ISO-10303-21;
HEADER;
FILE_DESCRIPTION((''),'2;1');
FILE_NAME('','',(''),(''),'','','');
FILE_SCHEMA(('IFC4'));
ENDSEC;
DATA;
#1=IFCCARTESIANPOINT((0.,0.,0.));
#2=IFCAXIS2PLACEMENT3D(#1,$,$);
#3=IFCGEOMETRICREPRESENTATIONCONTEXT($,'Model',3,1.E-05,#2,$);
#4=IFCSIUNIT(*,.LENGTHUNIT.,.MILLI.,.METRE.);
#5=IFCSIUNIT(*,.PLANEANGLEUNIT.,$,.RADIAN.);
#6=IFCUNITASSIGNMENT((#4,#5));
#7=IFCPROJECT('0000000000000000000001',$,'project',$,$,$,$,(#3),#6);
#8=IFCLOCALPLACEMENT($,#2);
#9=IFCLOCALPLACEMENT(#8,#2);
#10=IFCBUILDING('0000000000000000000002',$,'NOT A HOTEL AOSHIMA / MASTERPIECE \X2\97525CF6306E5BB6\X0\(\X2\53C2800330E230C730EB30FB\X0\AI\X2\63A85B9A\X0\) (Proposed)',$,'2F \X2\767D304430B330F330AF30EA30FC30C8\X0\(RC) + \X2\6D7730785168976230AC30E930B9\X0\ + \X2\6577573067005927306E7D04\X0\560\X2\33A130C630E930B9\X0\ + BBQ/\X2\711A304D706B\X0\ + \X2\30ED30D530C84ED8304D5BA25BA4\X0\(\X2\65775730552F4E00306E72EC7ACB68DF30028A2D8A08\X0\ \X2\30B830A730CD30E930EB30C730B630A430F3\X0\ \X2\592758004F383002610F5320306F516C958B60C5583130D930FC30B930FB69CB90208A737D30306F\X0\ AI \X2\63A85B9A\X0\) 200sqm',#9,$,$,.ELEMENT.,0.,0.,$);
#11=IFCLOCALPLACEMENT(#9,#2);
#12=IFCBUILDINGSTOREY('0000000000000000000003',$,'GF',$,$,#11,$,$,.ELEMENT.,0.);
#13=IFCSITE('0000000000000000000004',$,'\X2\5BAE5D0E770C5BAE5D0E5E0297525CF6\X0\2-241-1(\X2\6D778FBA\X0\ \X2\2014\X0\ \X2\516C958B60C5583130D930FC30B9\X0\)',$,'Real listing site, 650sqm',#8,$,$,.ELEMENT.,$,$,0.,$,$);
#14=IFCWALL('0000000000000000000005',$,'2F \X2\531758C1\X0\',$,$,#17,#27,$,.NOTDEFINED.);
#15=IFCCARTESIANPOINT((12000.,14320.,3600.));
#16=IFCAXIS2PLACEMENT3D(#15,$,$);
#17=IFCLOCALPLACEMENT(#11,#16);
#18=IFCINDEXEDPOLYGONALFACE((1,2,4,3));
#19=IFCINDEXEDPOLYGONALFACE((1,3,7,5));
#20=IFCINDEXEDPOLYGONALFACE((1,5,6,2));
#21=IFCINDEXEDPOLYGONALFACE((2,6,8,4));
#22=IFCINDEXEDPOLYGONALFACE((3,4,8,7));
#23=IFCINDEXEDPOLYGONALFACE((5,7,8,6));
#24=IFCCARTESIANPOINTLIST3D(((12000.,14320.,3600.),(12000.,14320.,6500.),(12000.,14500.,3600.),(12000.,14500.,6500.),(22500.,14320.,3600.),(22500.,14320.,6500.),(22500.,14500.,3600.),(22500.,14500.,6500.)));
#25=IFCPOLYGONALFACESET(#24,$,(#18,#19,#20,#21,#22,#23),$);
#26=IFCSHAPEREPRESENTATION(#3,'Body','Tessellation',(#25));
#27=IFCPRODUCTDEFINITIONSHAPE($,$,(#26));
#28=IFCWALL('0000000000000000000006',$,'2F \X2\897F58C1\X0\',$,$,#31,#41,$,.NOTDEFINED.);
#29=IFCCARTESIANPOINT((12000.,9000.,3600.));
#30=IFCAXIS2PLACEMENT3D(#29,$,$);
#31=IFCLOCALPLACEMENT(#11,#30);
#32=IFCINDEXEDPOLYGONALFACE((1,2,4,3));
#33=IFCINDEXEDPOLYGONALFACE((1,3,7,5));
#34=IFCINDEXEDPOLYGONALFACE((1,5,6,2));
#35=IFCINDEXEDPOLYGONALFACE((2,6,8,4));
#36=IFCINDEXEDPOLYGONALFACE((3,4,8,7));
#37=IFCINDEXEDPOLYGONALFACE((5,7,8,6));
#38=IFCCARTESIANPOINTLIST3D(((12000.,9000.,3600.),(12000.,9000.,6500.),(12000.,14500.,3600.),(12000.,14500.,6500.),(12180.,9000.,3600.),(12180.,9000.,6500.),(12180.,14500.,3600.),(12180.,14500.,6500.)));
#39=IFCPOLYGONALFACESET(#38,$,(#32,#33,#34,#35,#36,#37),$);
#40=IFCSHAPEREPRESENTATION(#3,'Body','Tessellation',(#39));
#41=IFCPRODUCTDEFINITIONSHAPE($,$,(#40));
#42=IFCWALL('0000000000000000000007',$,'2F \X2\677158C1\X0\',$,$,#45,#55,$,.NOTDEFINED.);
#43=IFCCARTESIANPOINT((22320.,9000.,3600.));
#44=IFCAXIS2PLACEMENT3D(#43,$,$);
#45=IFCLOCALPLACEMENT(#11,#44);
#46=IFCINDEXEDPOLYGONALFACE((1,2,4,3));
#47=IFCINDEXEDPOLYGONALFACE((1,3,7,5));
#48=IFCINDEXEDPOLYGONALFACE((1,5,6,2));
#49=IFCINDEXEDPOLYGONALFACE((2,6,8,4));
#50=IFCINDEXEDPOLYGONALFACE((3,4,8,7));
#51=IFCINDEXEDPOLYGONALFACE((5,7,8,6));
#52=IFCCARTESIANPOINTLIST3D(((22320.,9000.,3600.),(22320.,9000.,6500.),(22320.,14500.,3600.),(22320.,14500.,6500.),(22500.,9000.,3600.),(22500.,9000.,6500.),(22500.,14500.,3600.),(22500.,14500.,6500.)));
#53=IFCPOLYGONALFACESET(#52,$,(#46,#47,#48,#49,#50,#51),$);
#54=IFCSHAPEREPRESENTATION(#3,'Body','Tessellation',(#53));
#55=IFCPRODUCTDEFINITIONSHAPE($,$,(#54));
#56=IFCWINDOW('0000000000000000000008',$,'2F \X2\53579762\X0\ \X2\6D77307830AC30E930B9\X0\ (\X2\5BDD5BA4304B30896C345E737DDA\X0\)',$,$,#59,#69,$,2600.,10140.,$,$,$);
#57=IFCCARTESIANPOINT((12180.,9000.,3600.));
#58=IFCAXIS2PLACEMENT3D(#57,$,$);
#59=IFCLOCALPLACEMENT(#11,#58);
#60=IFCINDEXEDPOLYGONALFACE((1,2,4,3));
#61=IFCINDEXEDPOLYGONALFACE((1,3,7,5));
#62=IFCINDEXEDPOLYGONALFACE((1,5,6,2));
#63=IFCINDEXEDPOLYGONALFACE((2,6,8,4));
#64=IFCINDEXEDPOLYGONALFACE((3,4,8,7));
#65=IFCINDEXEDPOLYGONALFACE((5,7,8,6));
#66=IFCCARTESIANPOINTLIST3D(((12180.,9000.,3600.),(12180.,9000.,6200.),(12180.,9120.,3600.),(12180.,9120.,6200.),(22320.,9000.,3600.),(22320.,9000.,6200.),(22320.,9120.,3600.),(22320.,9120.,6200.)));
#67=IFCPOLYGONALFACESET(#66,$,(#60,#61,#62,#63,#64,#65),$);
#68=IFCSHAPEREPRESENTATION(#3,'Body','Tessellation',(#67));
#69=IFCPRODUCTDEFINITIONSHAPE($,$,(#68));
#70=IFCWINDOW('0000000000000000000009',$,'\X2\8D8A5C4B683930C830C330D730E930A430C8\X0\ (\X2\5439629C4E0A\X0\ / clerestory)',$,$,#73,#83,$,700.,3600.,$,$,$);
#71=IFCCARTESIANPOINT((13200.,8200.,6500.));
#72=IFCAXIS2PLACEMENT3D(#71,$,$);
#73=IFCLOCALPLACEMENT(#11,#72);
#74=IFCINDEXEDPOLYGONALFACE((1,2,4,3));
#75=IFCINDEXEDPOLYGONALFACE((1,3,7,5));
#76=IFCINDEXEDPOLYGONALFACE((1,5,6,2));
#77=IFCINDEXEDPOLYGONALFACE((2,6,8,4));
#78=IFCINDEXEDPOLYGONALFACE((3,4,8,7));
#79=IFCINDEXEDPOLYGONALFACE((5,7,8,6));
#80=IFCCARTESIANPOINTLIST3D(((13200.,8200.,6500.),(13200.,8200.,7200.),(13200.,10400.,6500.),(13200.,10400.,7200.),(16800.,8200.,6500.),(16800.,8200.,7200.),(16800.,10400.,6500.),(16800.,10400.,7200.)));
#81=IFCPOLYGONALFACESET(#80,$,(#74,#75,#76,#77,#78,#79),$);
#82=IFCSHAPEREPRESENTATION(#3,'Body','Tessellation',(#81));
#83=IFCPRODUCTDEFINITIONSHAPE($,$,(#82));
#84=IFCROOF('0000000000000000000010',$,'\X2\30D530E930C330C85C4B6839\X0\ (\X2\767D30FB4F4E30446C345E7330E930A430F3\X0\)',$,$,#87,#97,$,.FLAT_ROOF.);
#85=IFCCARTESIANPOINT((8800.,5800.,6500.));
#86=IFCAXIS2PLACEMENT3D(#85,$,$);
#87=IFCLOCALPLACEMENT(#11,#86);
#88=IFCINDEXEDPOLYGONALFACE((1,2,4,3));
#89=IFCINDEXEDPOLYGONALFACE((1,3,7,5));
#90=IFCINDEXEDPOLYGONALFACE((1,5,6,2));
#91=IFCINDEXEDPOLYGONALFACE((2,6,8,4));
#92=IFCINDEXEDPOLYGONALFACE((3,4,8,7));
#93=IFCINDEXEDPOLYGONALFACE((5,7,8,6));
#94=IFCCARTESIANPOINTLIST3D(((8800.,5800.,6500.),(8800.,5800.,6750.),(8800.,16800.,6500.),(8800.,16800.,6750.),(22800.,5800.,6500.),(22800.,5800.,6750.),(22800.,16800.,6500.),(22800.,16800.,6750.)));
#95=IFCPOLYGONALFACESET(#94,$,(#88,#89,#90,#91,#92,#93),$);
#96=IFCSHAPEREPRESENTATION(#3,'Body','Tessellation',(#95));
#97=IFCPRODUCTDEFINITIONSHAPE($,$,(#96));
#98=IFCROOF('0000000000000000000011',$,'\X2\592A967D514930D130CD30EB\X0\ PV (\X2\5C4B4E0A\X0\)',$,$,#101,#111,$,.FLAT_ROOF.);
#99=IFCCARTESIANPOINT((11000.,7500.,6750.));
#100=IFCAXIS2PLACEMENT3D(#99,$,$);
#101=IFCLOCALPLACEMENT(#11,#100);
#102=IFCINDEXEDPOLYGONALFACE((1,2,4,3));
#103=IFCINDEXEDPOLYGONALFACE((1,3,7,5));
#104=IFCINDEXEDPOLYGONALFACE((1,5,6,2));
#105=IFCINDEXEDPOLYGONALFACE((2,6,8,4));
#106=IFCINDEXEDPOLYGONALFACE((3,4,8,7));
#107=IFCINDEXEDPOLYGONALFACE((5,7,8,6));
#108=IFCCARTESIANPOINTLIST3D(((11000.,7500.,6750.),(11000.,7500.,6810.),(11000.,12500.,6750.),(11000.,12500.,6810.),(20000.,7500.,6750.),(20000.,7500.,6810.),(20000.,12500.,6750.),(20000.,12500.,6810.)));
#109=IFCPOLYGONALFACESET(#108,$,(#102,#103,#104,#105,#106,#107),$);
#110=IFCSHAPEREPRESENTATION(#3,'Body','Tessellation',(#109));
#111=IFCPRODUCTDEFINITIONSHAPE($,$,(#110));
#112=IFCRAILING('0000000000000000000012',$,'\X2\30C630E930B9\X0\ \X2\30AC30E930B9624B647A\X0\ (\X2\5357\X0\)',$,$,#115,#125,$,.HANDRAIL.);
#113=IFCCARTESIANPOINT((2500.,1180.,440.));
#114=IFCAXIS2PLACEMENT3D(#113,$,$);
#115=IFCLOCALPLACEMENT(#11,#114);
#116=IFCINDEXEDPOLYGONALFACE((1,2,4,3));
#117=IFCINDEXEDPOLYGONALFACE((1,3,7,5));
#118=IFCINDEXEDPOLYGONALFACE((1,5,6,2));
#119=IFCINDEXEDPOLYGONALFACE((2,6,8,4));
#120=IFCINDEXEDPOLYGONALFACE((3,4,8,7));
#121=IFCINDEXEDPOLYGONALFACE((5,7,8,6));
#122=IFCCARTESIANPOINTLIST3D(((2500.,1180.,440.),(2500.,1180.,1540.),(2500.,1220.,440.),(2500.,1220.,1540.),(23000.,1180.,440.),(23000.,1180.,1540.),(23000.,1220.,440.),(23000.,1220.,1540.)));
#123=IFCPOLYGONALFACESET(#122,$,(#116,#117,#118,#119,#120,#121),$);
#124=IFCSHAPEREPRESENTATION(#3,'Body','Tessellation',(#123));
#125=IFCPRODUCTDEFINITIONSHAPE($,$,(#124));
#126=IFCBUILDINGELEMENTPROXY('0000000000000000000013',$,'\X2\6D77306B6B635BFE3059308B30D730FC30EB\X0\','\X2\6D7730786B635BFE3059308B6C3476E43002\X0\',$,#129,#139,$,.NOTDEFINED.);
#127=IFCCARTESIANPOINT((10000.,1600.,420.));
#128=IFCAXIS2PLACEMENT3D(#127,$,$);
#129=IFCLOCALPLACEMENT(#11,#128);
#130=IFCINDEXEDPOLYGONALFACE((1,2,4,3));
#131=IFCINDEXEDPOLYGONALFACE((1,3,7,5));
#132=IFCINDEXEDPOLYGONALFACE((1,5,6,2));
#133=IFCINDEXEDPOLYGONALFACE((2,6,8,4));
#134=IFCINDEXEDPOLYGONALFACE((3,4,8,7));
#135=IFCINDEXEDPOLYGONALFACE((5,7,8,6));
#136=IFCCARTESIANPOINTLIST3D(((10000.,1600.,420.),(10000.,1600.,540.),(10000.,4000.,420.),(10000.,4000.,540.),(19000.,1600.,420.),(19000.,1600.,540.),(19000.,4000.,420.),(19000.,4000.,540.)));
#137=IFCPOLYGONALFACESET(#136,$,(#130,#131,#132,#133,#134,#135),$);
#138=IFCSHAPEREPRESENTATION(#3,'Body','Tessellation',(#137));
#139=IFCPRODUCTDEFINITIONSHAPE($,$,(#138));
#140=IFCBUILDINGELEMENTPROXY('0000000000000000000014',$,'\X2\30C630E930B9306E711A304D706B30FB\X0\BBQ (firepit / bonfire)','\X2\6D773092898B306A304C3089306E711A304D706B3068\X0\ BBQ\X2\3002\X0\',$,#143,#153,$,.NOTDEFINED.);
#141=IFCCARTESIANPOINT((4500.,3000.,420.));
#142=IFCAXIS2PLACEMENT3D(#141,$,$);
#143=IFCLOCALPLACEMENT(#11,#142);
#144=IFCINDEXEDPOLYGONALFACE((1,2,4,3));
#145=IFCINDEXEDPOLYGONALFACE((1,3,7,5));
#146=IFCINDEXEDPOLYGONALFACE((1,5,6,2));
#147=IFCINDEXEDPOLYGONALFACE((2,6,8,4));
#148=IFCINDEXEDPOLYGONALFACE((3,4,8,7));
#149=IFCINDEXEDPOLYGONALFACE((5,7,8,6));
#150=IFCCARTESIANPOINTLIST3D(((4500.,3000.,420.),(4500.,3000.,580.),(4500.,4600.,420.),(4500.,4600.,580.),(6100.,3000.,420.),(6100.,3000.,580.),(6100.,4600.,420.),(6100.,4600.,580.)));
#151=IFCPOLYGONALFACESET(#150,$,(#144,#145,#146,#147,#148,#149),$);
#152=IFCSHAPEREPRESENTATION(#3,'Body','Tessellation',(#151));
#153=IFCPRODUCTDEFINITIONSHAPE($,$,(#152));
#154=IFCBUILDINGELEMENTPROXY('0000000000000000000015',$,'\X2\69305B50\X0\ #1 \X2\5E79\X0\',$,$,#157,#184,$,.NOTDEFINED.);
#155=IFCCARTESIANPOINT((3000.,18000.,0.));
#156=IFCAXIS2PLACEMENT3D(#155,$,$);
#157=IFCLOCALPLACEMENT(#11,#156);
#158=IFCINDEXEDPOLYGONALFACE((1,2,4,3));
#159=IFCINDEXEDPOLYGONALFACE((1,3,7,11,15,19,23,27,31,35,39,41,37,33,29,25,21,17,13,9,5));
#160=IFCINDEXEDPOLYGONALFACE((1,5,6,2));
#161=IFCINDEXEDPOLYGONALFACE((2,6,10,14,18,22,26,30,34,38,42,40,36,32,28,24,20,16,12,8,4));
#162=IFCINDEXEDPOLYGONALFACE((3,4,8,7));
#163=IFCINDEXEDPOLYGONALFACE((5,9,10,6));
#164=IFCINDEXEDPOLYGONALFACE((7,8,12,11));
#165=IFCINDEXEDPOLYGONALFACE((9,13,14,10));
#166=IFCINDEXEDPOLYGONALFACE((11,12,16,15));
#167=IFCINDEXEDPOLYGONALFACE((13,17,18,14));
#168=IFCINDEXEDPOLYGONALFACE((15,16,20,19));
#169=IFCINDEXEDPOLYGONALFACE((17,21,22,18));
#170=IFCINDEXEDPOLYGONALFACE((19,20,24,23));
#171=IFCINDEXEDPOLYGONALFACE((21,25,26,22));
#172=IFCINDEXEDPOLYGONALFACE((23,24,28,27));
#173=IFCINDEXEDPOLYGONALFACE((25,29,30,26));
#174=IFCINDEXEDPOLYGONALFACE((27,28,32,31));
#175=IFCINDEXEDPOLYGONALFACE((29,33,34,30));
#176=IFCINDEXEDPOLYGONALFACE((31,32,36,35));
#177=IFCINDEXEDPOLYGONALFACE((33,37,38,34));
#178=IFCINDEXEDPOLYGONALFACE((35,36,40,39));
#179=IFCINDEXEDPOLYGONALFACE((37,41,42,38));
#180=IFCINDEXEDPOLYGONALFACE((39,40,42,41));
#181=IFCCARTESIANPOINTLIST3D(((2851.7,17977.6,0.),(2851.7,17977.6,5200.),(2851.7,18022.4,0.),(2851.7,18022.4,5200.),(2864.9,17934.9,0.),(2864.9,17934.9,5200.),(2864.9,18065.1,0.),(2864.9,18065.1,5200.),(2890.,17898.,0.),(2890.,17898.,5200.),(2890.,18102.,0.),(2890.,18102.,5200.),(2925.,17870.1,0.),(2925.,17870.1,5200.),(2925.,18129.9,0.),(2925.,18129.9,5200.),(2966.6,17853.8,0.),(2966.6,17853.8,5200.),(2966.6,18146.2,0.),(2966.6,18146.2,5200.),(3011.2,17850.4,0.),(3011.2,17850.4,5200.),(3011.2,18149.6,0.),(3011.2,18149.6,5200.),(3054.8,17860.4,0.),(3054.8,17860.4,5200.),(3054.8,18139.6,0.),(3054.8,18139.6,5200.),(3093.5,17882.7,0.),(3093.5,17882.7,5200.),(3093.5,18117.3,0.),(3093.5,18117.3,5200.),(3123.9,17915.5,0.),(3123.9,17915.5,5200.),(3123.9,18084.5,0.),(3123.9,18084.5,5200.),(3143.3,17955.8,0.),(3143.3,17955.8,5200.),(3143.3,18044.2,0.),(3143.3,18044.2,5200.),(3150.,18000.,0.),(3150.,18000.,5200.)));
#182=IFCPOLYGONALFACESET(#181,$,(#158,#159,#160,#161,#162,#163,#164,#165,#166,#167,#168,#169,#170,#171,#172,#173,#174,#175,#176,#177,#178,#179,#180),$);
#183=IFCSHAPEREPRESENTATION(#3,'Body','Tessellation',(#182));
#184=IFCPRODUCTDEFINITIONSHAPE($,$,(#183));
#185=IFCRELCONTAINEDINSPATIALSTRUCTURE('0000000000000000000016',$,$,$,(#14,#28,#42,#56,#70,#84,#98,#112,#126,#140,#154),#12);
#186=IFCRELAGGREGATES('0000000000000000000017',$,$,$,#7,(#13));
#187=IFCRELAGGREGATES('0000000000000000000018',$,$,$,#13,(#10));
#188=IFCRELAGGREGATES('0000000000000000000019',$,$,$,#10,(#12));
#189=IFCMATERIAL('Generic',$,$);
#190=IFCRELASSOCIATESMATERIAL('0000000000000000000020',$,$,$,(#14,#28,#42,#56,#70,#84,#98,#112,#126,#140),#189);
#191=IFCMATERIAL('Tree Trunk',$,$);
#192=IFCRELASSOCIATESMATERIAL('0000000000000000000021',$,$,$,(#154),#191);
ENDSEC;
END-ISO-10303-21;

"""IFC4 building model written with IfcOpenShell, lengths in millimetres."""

from ifc_helpers import new_model, si_unit, frame, frame_2d, origin, origin_2d, place, context, project, spatial, rectangle, circle, extrude, material, element, save


model = new_model("IFC4")

# Units and contexts
model_context = context("Model", 3, precision=1e-05, world=origin())
ifc_project = project(units=[si_unit("LENGTHUNIT", "METRE", prefix="MILLI"), si_unit("PLANEANGLEUNIT", "RADIAN")], contexts=[model_context])

# Site, building, storey
site_placement = place(None, origin())
site = spatial("IfcSite", under=ifc_project, at=site_placement, Name="宮崎県宮崎市青島2-241-1(海辺 — 公開情報ベース)", ObjectType="Real listing site, 650sqm", CompositionType="ELEMENT", RefElevation=0.0)
building_placement = place(site_placement, origin())
building = spatial("IfcBuilding", under=site, at=building_placement, Name="NOT A HOTEL AOSHIMA / MASTERPIECE 青島の家(参考モデル・AI推定) (Proposed)", ObjectType="2F 白いコンクリート(RC) + 海へ全面ガラス + 敷地最大の約560㎡テラス + BBQ/焚き火 + ロフト付き客室(敷地唯一の独立棟。設計 ジェネラルデザイン 大堀伸。意匠は公開情報ベース・構造詳細は AI 推定) 200sqm", CompositionType="ELEMENT", ElevationOfRefHeight=0.0, ElevationOfTerrain=0.0)
storey_placement = place(building_placement, origin())
storey = spatial("IfcBuildingStorey", under=building, at=storey_placement, Name="GF", CompositionType="ELEMENT", Elevation=0.0)

# Shared definitions
ifc_material_1 = material(Name="Generic")

# Walls
wall_1_placement = place(storey_placement, frame((12000.0, 14320.0, 3600.0)))
element("IfcWall", 1, at=wall_1_placement, inside=storey, material=ifc_material_1, Name="2F 北壁", PredefinedType="NOTDEFINED", context=model_context, shape_type="SweptSolid", body=[
    extrude(rectangle(XDim=10500.0, YDim=180.0, at=frame_2d((5250.0, 90.0))), frame((12000.0, 14320.0, 3600.0)), (0.0, 0.0, 1.0), 2900.0),
])
wall_2_placement = place(storey_placement, frame((12000.0, 9000.0, 3600.0)))
element("IfcWall", 2, at=wall_2_placement, inside=storey, material=ifc_material_1, Name="2F 西壁", PredefinedType="NOTDEFINED", context=model_context, shape_type="SweptSolid", body=[
    extrude(rectangle(XDim=180.0, YDim=5500.0, at=frame_2d((90.0, 2750.0))), frame((12000.0, 9000.0, 3600.0)), (0.0, 0.0, 1.0), 2900.0),
])
wall_3_placement = place(storey_placement, frame((22320.0, 9000.0, 3600.0)))
element("IfcWall", 3, at=wall_3_placement, inside=storey, material=ifc_material_1, Name="2F 東壁", PredefinedType="NOTDEFINED", context=model_context, shape_type="SweptSolid", body=[
    extrude(rectangle(XDim=180.0, YDim=5500.0, at=frame_2d((90.0, 2750.0))), frame((22320.0, 9000.0, 3600.0)), (0.0, 0.0, 1.0), 2900.0),
])

# Windows
window_1_placement = place(storey_placement, frame((12180.0, 9000.0, 3600.0)))
element("IfcWindow", 4, at=window_1_placement, inside=storey, material=ifc_material_1, Name="2F 南面 海へガラス (寝室から水平線)", OverallHeight=2600.0, OverallWidth=10140.0, context=model_context, shape_type="SweptSolid", body=[
    extrude(rectangle(XDim=10140.0, YDim=120.0, at=frame_2d((5070.0, 60.0))), frame((12180.0, 9000.0, 3600.0)), (0.0, 0.0, 1.0), 2600.0),
])
window_2_placement = place(storey_placement, frame((13200.0, 8200.0, 6500.0)))
element("IfcWindow", 5, at=window_2_placement, inside=storey, material=ifc_material_1, Name="越屋根トップライト (吹抜上 / clerestory)", OverallHeight=700.0, OverallWidth=3600.0, context=model_context, shape_type="SweptSolid", body=[
    extrude(rectangle(XDim=3600.0, YDim=2200.0, at=frame_2d((1800.0, 1100.0))), frame((13200.0, 8200.0, 6500.0)), (0.0, 0.0, 1.0), 700.0),
])

# Roofs
roof_1_placement = place(storey_placement, frame((8800.0, 5800.0, 6500.0)))
element("IfcRoof", 6, at=roof_1_placement, inside=storey, material=ifc_material_1, Name="フラット屋根 (白・低い水平ライン)", PredefinedType="FLAT_ROOF", context=model_context, shape_type="SweptSolid", body=[
    extrude(rectangle(XDim=14000.0, YDim=11000.0, at=frame_2d((7000.0, 5500.0))), frame((8800.0, 5800.0, 6500.0)), (0.0, 0.0, 1.0), 250.0),
])
roof_2_placement = place(storey_placement, frame((11000.0, 7500.0, 6750.0)))
element("IfcRoof", 7, at=roof_2_placement, inside=storey, material=ifc_material_1, Name="太陽光パネル PV (屋上)", PredefinedType="FLAT_ROOF", context=model_context, shape_type="SweptSolid", body=[
    extrude(rectangle(XDim=9000.0, YDim=5000.0, at=frame_2d((4500.0, 2500.0))), frame((11000.0, 7500.0, 6750.0)), (0.0, 0.0, 1.0), 60.0),
])

# Railing
railing_placement = place(storey_placement, frame((2500.0, 1180.0, 440.0)))
element("IfcRailing", 8, at=railing_placement, inside=storey, material=ifc_material_1, Name="テラス ガラス手摺 (南)", PredefinedType="HANDRAIL", context=model_context, shape_type="SweptSolid", body=[
    extrude(rectangle(XDim=20500.0, YDim=40.0, at=frame_2d((10250.0, 20.0))), frame((2500.0, 1180.0, 440.0)), (0.0, 0.0, 1.0), 1100.0),
])

# Building element proxies
proxy_1_placement = place(storey_placement, frame((10000.0, 1600.0, 420.0)))
element("IfcBuildingElementProxy", 9, at=proxy_1_placement, inside=storey, material=ifc_material_1, Name="海に正対するプール", Description="海へ正対する水盤。", PredefinedType="NOTDEFINED", context=model_context, shape_type="SweptSolid", body=[
    extrude(rectangle(XDim=9000.0, YDim=2400.0, at=frame_2d((4500.0, 1200.0))), frame((10000.0, 1600.0, 420.0)), (0.0, 0.0, 1.0), 120.0),
])
proxy_2_placement = place(storey_placement, frame((4500.0, 3000.0, 420.0)))
element("IfcBuildingElementProxy", 10, at=proxy_2_placement, inside=storey, material=ifc_material_1, Name="テラスの焚き火・BBQ (firepit / bonfire)", Description="海を見ながらの焚き火と BBQ。", PredefinedType="NOTDEFINED", context=model_context, shape_type="SweptSolid", body=[
    extrude(rectangle(XDim=1600.0, YDim=1600.0, at=frame_2d((800.0, 800.0))), frame((4500.0, 3000.0, 420.0)), (0.0, 0.0, 1.0), 160.0),
])
ifc_material_2 = material(Name="Tree Trunk")
proxy_3_placement = place(storey_placement, frame((3000.0, 18000.0, 0.0)))
element("IfcBuildingElementProxy", 11, at=proxy_3_placement, inside=storey, material=ifc_material_2, Name="椰子 #1 幹", PredefinedType="NOTDEFINED", context=model_context, shape_type="SweptSolid", body=[
    extrude(circle(Radius=150.0, at=origin_2d()), frame((3000.0, 18000.0, 0.0)), (0.0, 0.0, 1.0), 5200.0),
])

save(model, "model.ifc")
